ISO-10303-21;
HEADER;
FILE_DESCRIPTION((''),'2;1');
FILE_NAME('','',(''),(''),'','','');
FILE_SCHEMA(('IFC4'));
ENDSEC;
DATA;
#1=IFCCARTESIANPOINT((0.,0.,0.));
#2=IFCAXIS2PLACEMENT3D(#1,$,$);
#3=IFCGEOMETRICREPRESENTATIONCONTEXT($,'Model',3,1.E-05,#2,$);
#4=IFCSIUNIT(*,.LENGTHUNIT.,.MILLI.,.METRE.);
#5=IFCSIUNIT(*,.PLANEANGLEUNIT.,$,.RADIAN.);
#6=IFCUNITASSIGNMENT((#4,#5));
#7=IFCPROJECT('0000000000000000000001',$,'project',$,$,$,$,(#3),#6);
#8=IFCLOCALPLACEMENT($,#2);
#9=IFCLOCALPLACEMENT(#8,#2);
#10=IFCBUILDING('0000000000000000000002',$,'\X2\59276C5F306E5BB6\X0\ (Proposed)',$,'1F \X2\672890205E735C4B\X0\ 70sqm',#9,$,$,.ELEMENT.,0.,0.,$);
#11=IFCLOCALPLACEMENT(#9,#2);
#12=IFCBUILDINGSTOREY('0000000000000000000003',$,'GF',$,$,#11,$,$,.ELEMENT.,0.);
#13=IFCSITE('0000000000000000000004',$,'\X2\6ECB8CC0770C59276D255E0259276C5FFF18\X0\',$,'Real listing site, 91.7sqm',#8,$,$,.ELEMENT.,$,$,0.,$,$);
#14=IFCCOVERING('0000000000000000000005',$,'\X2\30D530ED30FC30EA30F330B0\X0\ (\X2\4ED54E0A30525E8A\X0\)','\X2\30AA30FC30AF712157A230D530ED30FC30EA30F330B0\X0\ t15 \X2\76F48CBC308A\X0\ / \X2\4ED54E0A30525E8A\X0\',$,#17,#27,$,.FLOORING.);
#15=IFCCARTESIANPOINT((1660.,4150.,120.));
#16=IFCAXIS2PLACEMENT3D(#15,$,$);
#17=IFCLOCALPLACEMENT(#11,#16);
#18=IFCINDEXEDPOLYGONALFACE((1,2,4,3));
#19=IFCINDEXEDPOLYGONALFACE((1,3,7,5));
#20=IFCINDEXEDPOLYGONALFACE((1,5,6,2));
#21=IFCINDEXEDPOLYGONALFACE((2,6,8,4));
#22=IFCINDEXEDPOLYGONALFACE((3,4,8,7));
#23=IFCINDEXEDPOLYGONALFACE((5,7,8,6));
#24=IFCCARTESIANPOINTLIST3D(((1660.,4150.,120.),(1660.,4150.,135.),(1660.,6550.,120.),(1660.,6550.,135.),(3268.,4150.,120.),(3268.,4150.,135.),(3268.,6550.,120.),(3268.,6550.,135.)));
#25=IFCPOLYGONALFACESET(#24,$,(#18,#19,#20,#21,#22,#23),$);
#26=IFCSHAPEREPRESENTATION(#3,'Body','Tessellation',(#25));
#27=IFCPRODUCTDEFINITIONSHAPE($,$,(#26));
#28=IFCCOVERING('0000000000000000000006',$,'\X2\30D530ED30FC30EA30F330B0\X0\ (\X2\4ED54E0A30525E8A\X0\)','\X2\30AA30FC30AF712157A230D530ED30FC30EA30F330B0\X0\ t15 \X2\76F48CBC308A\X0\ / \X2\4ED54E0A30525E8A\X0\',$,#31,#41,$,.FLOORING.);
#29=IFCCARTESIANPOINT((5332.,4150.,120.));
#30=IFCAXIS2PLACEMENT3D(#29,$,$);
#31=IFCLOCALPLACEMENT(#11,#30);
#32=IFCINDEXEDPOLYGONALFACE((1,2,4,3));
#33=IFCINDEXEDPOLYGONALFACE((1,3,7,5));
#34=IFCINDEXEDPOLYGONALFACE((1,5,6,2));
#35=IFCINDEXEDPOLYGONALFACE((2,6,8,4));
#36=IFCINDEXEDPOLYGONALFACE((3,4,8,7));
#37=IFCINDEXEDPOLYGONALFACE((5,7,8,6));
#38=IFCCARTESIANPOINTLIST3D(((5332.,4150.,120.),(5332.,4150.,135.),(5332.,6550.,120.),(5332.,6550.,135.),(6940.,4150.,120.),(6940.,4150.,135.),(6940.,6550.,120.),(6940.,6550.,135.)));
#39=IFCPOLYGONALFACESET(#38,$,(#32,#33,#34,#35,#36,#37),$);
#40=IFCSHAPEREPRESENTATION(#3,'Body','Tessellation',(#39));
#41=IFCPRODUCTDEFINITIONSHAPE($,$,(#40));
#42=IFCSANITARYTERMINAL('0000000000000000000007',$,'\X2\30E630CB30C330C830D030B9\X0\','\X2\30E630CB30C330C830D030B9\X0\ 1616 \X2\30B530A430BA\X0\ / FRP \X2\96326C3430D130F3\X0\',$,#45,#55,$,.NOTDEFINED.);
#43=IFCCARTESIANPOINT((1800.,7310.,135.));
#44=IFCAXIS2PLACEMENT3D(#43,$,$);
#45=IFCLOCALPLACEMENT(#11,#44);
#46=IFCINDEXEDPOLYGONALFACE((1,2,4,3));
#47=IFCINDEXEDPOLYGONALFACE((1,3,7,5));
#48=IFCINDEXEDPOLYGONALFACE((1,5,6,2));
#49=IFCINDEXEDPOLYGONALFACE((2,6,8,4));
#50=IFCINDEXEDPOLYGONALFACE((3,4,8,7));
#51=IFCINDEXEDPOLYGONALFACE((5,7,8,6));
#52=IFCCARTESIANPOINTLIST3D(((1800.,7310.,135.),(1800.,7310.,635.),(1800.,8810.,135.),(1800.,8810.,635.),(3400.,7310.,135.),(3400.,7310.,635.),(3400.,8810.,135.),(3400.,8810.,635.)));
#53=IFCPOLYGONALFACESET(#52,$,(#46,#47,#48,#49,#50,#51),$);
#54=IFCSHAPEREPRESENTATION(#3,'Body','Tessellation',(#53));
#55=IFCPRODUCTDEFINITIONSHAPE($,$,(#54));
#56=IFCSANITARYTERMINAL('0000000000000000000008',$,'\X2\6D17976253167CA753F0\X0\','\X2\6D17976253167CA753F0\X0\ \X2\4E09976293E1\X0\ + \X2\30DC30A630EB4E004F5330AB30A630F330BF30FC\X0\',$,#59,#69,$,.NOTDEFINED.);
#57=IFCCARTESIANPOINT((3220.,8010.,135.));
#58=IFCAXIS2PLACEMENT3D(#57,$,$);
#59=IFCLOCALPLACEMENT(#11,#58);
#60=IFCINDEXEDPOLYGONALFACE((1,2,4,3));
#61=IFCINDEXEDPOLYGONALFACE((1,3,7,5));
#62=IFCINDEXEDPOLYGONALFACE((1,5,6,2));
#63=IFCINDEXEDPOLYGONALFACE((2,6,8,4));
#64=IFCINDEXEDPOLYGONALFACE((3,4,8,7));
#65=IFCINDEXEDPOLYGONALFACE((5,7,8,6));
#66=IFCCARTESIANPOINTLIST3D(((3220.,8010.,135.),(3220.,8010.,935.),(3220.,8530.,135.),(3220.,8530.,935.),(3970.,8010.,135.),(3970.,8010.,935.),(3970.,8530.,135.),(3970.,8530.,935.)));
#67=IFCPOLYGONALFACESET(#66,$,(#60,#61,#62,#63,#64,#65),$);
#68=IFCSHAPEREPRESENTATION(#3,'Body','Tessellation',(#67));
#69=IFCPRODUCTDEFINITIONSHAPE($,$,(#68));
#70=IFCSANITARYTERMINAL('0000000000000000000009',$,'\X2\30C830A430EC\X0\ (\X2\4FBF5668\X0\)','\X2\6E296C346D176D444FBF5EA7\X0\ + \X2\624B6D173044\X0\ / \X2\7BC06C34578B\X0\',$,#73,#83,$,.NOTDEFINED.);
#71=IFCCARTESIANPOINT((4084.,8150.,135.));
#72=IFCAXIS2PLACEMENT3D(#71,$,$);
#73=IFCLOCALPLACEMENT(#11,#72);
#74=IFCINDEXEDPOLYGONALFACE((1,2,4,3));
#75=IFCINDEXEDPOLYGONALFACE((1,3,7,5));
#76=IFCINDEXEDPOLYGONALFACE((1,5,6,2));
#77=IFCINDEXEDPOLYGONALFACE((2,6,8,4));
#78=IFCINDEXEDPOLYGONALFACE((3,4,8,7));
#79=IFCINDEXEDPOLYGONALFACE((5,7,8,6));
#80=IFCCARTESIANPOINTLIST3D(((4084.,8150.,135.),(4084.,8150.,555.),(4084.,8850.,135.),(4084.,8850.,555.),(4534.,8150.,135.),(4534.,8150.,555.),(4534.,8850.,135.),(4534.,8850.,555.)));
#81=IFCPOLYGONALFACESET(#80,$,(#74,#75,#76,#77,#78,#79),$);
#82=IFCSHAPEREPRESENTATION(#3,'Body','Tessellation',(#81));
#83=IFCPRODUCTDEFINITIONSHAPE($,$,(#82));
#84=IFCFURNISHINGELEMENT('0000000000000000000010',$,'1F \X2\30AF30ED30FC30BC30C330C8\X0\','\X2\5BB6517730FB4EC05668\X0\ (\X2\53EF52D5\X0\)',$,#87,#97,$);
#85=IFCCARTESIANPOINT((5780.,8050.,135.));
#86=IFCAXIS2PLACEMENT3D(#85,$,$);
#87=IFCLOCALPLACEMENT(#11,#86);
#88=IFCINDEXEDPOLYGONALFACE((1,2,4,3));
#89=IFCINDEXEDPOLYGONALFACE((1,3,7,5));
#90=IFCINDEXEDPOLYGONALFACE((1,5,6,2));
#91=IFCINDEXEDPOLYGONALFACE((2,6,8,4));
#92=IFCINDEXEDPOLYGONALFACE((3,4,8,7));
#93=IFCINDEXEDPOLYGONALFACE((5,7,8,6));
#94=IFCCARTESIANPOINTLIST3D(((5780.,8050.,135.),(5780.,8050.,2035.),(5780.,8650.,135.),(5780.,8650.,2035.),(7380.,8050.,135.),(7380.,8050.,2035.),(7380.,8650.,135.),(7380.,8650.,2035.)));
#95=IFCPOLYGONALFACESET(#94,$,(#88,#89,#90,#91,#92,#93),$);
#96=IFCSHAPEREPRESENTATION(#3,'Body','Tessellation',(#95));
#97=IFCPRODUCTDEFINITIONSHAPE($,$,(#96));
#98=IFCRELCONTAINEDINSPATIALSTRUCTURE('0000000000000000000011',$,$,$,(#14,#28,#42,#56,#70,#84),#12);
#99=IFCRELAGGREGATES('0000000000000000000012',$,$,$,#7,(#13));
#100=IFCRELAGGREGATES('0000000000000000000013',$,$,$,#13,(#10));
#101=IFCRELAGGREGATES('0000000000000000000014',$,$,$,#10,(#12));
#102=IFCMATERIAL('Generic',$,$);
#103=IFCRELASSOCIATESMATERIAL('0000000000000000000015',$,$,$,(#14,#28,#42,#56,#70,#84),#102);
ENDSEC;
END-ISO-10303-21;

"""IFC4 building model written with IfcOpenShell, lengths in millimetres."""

from ifc_helpers import new_model, si_unit, frame, frame_2d, origin, place, context, project, spatial, rectangle, extrude, material, element, save


model = new_model("IFC4")

# Units and contexts
model_context = context("Model", 3, precision=1e-05, world=origin())
ifc_project = project(units=[si_unit("LENGTHUNIT", "METRE", prefix="MILLI"), si_unit("PLANEANGLEUNIT", "RADIAN")], contexts=[model_context])

# Site, building, storey
site_placement = place(None, origin())
site = spatial("IfcSite", under=ifc_project, at=site_placement, Name="滋賀県大津市大江８", ObjectType="Real listing site, 91.7sqm", CompositionType="ELEMENT", RefElevation=0.0)
building_placement = place(site_placement, origin())
building = spatial("IfcBuilding", under=site, at=building_placement, Name="大江の家 (Proposed)", ObjectType="1F 木造平屋 70sqm", CompositionType="ELEMENT", ElevationOfRefHeight=0.0, ElevationOfTerrain=0.0)
storey_placement = place(building_placement, origin())
storey = spatial("IfcBuildingStorey", under=building, at=storey_placement, Name="GF", CompositionType="ELEMENT", Elevation=0.0)

# Coverings
ifc_material_1 = material(Name="Generic")
covering_1_placement = place(storey_placement, frame((1660.0, 4150.0, 120.0)))
element("IfcCovering", 1, at=covering_1_placement, inside=storey, material=ifc_material_1, Name="フローリング (仕上げ床)", Description="オーク無垢フローリング t15 直貼り / 仕上げ床", PredefinedType="FLOORING", context=model_context, shape_type="SweptSolid", body=[
    extrude(rectangle(XDim=1608.0, YDim=2400.0, at=frame_2d((804.0, 1200.0))), frame((1660.0, 4150.0, 120.0)), (0.0, 0.0, 1.0), 15.0),
])
covering_2_placement = place(storey_placement, frame((5332.0, 4150.0, 120.0)))
element("IfcCovering", 2, at=covering_2_placement, inside=storey, material=ifc_material_1, Name="フローリング (仕上げ床)", Description="オーク無垢フローリング t15 直貼り / 仕上げ床", PredefinedType="FLOORING", context=model_context, shape_type="SweptSolid", body=[
    extrude(rectangle(XDim=1608.0, YDim=2400.0, at=frame_2d((804.0, 1200.0))), frame((5332.0, 4150.0, 120.0)), (0.0, 0.0, 1.0), 15.0),
])

# Sanitary terminals
sanitary_terminal_1_placement = place(storey_placement, frame((1800.0, 7310.0, 135.0)))
element("IfcSanitaryTerminal", 3, at=sanitary_terminal_1_placement, inside=storey, material=ifc_material_1, Name="ユニットバス", Description="ユニットバス 1616 サイズ / FRP 防水パン", PredefinedType="NOTDEFINED", context=model_context, shape_type="SweptSolid", body=[
    extrude(rectangle(XDim=1600.0, YDim=1500.0, at=frame_2d((800.0, 750.0))), frame((1800.0, 7310.0, 135.0)), (0.0, 0.0, 1.0), 500.0),
])
sanitary_terminal_2_placement = place(storey_placement, frame((3220.0, 8010.0, 135.0)))
element("IfcSanitaryTerminal", 4, at=sanitary_terminal_2_placement, inside=storey, material=ifc_material_1, Name="洗面化粧台", Description="洗面化粧台 三面鏡 + ボウル一体カウンター", PredefinedType="NOTDEFINED", context=model_context, shape_type="SweptSolid", body=[
    extrude(rectangle(XDim=750.0, YDim=520.0, at=frame_2d((375.0, 260.0))), frame((3220.0, 8010.0, 135.0)), (0.0, 0.0, 1.0), 800.0),
])
sanitary_terminal_3_placement = place(storey_placement, frame((4084.0, 8150.0, 135.0)))
element("IfcSanitaryTerminal", 5, at=sanitary_terminal_3_placement, inside=storey, material=ifc_material_1, Name="トイレ (便器)", Description="温水洗浄便座 + 手洗い / 節水型", PredefinedType="NOTDEFINED", context=model_context, shape_type="SweptSolid", body=[
    extrude(rectangle(XDim=450.0, YDim=700.0, at=frame_2d((225.0, 350.0))), frame((4084.0, 8150.0, 135.0)), (0.0, 0.0, 1.0), 420.0),
])

# Furnishing element
furnishing_placement = place(storey_placement, frame((5780.0, 8050.0, 135.0)))
element("IfcFurnishingElement", 6, at=furnishing_placement, inside=storey, material=ifc_material_1, Name="1F クローゼット", Description="家具・什器 (可動)", context=model_context, shape_type="SweptSolid", body=[
    extrude(rectangle(XDim=1600.0, YDim=600.0, at=frame_2d((800.0, 300.0))), frame((5780.0, 8050.0, 135.0)), (0.0, 0.0, 1.0), 1900.0),
])

save(model, "model.ifc")
